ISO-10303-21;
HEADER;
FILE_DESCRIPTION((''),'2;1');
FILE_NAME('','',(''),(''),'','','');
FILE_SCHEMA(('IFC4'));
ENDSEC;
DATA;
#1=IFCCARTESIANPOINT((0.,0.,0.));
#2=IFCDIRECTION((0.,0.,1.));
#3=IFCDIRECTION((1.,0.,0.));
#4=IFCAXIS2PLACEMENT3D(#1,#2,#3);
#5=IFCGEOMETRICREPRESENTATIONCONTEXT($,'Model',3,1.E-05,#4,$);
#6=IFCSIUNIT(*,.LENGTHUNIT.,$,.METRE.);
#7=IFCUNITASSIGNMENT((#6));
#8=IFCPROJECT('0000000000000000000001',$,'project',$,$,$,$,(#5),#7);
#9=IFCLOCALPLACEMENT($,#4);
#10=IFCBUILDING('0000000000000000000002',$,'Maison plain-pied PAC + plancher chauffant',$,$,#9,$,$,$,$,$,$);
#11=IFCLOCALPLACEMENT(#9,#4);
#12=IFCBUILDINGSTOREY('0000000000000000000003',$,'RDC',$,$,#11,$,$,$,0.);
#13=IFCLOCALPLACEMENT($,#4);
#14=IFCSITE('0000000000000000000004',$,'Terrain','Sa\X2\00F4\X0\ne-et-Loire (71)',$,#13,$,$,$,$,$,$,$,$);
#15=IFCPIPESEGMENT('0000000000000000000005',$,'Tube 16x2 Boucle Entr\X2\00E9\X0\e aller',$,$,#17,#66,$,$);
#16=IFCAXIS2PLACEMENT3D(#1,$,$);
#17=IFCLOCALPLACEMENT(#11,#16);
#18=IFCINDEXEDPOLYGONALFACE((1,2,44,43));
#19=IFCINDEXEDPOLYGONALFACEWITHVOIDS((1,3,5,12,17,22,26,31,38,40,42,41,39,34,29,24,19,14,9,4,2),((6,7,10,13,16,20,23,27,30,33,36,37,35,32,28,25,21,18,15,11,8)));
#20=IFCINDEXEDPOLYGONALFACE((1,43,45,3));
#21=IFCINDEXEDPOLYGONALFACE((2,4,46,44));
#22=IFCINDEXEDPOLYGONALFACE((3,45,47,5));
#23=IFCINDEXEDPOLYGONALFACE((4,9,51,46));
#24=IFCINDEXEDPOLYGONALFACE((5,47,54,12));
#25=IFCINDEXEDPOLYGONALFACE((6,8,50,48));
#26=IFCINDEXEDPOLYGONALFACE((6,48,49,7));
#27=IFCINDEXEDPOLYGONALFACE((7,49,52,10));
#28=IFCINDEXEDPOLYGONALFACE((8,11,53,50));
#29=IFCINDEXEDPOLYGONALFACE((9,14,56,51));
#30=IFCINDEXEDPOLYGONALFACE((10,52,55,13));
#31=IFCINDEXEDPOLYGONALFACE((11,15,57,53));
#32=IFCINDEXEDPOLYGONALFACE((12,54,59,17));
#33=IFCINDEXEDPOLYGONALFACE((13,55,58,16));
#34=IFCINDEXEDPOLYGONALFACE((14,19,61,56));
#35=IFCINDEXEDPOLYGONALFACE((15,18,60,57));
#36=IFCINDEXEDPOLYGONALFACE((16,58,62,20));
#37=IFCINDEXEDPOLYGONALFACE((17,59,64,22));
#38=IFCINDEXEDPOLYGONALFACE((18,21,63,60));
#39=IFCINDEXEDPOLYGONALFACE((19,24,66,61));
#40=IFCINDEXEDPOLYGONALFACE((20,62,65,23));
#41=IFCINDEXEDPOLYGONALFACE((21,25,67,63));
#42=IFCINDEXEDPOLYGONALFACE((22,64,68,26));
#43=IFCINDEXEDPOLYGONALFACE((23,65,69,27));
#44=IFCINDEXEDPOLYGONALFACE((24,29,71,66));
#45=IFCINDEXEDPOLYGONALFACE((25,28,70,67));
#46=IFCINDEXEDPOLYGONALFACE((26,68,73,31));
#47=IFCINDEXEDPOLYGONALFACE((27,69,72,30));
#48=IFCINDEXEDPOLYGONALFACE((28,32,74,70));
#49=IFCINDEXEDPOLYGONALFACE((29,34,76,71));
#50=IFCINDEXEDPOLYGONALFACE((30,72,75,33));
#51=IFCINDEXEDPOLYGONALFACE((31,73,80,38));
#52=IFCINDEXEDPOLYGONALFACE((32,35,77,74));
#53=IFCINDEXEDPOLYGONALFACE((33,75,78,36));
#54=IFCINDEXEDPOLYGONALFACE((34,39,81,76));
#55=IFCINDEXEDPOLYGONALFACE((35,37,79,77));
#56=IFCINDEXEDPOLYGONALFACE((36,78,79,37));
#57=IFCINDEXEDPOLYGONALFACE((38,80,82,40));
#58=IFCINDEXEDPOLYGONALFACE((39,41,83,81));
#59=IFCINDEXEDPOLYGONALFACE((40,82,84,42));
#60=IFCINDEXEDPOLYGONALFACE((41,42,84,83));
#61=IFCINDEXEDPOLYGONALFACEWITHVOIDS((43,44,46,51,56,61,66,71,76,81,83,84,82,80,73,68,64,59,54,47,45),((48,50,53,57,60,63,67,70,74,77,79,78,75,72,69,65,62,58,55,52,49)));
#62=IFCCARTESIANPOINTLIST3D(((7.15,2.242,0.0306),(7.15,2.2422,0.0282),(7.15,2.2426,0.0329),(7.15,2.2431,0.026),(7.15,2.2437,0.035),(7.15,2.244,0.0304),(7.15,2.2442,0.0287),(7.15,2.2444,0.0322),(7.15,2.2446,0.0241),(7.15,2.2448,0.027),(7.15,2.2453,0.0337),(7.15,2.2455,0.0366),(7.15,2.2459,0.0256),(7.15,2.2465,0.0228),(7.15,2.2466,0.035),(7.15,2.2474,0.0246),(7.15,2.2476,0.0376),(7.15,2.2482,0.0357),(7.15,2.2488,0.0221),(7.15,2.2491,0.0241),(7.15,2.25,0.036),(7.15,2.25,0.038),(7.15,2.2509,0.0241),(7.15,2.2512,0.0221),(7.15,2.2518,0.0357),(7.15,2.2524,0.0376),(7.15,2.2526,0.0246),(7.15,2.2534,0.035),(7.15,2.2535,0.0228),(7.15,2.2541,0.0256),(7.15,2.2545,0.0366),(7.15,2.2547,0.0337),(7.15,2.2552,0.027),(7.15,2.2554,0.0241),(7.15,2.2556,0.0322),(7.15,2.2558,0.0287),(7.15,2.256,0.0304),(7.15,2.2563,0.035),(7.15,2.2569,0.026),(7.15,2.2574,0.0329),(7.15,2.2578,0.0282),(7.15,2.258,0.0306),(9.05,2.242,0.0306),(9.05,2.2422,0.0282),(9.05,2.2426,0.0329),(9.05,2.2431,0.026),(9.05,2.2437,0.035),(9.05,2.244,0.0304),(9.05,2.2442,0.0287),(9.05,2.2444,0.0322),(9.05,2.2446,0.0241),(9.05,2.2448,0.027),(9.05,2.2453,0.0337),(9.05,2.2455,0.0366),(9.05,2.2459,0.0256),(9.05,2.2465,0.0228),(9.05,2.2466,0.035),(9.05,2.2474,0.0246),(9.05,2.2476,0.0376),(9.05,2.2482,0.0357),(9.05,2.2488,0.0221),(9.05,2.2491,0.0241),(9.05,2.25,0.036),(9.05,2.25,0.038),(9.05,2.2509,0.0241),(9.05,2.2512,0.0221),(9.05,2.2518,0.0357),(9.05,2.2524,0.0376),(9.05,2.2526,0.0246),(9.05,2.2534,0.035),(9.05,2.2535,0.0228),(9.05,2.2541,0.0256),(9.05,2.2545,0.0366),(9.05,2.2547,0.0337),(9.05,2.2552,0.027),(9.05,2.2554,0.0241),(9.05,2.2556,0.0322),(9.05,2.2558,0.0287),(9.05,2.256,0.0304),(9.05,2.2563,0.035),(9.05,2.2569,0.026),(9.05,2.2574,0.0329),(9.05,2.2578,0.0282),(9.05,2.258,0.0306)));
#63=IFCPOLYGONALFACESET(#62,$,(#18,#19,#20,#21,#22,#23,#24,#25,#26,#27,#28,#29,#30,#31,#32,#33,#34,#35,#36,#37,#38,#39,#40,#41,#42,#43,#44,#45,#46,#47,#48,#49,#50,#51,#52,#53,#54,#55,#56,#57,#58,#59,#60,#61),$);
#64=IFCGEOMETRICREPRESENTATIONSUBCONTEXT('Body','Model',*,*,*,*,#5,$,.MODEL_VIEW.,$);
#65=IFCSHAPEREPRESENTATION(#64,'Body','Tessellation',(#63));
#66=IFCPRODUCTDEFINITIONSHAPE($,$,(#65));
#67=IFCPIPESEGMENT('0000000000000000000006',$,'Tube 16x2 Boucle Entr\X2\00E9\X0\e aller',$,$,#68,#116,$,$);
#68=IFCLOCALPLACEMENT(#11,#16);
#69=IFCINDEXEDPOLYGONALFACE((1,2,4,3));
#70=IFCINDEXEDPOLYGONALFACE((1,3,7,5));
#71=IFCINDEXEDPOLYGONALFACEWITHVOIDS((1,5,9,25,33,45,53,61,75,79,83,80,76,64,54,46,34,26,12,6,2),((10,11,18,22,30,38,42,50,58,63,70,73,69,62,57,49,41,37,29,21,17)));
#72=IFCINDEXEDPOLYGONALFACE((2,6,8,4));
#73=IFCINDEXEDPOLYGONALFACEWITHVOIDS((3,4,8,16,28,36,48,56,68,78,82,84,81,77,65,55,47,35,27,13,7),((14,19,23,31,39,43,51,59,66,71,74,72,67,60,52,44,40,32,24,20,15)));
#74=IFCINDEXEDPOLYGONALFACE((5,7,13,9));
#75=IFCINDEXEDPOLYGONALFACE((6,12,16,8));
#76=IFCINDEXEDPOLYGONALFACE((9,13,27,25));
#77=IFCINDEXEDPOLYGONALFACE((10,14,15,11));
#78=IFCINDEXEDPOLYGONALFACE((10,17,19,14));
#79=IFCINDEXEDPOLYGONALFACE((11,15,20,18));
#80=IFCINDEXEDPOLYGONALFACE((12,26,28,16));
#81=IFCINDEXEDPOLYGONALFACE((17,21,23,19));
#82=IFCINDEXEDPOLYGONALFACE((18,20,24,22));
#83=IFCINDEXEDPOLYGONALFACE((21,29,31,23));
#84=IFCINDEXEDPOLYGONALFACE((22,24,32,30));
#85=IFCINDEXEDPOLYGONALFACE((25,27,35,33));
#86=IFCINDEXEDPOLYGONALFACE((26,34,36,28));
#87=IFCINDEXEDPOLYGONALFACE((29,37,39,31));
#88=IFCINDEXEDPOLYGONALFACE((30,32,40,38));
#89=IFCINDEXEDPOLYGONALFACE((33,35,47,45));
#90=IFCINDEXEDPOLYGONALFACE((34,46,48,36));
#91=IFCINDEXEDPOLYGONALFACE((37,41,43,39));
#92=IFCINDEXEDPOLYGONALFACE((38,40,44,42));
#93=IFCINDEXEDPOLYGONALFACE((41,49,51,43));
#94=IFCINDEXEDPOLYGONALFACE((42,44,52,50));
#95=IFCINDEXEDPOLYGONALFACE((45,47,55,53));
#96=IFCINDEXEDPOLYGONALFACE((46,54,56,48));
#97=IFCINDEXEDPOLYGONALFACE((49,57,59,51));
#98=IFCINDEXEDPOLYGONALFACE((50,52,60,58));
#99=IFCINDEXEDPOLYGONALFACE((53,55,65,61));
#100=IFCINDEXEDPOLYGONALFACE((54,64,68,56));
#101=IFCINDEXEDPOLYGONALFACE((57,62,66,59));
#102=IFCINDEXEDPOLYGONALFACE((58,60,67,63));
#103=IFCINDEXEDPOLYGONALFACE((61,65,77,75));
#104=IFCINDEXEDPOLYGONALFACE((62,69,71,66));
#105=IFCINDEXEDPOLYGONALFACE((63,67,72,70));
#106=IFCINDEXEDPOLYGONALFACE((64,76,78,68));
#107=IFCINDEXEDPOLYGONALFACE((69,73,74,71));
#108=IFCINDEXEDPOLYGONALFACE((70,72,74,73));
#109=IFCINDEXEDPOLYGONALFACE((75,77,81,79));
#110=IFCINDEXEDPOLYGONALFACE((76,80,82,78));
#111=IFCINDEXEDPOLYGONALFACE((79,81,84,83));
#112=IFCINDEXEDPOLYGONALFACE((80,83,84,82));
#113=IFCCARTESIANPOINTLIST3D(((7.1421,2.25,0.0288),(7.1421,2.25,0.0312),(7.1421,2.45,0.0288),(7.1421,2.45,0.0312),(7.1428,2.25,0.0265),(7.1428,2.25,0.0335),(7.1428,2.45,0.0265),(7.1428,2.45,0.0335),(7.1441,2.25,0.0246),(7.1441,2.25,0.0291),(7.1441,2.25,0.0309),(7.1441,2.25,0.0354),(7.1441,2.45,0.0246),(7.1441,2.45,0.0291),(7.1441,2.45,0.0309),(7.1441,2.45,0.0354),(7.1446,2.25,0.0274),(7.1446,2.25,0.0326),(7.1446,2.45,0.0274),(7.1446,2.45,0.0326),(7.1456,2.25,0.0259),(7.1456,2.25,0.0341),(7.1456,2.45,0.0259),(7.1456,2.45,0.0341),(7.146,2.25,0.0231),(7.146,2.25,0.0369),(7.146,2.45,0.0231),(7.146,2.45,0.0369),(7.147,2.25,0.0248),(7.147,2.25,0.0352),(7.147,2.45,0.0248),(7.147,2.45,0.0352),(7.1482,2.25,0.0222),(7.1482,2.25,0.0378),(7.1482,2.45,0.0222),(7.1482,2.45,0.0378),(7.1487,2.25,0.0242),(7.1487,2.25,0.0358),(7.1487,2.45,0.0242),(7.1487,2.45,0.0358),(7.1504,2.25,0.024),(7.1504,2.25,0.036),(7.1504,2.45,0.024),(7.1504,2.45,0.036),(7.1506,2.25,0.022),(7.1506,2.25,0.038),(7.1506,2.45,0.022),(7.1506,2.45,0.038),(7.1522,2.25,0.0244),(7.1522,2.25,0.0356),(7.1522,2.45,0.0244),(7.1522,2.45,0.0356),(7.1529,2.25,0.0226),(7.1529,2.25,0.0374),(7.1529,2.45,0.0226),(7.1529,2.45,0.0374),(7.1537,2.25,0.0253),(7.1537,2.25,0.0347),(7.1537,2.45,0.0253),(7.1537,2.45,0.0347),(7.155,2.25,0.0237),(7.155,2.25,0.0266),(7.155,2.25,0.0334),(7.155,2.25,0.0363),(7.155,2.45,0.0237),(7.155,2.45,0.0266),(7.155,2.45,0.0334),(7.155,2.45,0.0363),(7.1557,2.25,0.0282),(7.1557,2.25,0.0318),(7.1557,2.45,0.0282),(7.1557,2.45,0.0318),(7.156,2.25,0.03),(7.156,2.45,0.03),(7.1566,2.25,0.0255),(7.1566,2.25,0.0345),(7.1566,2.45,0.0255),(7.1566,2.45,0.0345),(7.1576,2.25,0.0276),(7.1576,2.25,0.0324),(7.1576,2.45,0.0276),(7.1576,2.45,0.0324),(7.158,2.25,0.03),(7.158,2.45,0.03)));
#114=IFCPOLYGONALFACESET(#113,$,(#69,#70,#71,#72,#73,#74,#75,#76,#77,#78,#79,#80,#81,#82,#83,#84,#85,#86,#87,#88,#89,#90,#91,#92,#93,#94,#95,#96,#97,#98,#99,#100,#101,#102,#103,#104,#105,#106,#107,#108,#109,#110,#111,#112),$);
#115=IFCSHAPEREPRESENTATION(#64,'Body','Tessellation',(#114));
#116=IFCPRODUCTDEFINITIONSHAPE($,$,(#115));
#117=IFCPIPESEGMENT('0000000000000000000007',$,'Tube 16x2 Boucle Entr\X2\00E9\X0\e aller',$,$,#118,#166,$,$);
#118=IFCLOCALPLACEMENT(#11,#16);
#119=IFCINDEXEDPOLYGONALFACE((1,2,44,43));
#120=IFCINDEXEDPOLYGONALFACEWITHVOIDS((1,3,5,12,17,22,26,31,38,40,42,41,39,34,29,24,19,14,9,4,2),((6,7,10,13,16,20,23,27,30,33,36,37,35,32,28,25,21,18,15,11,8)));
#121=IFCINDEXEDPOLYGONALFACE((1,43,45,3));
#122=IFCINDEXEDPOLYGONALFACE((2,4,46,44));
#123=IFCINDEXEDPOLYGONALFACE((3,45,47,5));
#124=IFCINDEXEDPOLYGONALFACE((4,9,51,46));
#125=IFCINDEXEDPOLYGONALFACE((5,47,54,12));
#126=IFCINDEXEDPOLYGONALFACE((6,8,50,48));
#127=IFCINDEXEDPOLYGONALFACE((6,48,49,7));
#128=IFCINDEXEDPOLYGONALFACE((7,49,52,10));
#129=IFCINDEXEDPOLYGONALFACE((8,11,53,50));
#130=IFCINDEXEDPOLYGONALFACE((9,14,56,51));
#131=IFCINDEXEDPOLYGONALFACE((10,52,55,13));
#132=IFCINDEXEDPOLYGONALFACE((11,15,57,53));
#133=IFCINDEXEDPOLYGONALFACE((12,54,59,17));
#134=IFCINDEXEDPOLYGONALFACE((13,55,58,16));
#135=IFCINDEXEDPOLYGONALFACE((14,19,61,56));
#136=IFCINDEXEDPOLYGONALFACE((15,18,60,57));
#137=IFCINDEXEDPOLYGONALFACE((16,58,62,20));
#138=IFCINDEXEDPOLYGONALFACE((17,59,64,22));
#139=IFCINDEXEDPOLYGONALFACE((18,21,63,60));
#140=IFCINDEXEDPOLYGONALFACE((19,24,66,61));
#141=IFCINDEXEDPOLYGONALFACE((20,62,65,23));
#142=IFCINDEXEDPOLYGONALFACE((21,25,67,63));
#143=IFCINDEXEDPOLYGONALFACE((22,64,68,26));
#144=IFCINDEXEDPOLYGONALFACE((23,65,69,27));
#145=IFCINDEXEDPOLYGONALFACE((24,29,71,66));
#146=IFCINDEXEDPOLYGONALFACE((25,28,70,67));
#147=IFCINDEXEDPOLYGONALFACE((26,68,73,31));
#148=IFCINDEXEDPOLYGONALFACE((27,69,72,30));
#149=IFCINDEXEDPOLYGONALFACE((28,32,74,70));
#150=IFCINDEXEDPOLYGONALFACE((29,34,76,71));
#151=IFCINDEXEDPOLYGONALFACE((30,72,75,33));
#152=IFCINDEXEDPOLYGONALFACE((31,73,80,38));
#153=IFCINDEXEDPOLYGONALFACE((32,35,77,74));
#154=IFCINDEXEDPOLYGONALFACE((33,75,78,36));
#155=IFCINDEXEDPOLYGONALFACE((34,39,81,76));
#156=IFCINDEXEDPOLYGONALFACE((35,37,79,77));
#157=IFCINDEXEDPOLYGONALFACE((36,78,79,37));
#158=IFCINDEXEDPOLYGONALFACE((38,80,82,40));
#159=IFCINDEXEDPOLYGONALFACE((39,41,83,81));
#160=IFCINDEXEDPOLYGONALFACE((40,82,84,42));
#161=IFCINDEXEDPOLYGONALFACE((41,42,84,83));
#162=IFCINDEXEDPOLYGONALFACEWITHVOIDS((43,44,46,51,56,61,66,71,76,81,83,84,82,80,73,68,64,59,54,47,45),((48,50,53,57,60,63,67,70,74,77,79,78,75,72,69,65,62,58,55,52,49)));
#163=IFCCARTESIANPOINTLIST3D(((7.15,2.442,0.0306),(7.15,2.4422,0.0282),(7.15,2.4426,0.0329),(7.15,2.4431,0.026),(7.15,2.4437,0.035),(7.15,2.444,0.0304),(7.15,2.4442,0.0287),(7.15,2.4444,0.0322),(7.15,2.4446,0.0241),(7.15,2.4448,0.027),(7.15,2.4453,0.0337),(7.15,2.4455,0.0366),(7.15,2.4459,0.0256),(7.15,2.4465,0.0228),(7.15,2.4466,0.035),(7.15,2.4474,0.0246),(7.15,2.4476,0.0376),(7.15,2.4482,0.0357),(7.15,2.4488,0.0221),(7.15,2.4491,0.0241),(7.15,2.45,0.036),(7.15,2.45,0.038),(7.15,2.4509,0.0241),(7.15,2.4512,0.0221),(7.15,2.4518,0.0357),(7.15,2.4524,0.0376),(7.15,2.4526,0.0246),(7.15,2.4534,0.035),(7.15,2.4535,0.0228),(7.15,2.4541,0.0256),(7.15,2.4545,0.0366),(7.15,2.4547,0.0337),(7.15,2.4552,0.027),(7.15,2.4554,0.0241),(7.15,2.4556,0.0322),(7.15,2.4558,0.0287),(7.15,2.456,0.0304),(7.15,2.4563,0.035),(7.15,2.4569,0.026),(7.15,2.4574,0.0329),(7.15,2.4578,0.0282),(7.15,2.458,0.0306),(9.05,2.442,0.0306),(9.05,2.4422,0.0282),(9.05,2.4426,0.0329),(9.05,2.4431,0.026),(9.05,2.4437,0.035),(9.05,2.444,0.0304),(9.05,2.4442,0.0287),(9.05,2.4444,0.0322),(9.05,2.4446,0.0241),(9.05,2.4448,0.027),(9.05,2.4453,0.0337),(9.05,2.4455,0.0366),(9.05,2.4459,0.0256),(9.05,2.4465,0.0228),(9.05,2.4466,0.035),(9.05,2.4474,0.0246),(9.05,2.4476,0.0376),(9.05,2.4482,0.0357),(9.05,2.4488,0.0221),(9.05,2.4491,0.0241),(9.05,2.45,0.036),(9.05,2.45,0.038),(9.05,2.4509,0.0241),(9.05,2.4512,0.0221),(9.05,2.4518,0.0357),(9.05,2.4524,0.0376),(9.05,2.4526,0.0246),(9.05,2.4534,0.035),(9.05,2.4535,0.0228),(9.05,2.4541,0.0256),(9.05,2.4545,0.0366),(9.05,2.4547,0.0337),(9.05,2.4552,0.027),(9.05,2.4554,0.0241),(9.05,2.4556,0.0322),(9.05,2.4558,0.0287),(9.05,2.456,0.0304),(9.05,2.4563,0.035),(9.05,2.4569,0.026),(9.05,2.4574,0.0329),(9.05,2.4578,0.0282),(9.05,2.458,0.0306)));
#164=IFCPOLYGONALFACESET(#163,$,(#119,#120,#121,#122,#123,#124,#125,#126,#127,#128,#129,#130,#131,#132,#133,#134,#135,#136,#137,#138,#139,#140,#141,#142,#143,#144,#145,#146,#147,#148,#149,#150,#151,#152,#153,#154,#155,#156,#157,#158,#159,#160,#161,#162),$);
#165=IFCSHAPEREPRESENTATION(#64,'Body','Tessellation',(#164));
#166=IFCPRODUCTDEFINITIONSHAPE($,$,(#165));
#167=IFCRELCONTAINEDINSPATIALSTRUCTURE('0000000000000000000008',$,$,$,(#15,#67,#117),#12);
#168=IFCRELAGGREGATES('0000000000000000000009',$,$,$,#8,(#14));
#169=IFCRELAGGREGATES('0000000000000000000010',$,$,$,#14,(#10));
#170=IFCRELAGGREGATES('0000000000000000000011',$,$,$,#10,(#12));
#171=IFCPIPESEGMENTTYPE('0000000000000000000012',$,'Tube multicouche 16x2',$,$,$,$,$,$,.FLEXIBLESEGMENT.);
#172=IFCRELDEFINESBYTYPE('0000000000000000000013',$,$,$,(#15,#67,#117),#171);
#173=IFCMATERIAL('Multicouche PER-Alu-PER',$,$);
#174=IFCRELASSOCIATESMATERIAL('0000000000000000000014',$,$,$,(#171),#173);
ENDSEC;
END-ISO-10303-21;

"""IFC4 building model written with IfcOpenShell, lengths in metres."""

from ifc_helpers import new_model, si_unit, frame, origin_with_axes, place, context, subcontext, project, spatial, hollow_circle, extrude, material, type_object, element, save


model = new_model("IFC4")

# Units and contexts
model_context = context("Model", 3, precision=1e-05, world=origin_with_axes())
body_context = subcontext(model_context, "Body", "Model", "MODEL_VIEW")
ifc_project = project(units=[si_unit("LENGTHUNIT", "METRE")], contexts=[model_context])

# Site, building, storey
site_placement = place(None, origin_with_axes())
site = spatial("IfcSite", under=ifc_project, at=site_placement, Name="Terrain", Description="Saône-et-Loire (71)")
building_placement = place(None, origin_with_axes())
building = spatial("IfcBuilding", under=site, at=building_placement, Name="Maison plain-pied PAC + plancher chauffant")
storey_placement = place(building_placement, origin_with_axes())
storey = spatial("IfcBuildingStorey", under=building, at=storey_placement, Name="RDC", Elevation=0.0)

# Pipe segments
ifc_material_1 = material(Name="Multicouche PER-Alu-PER")
pipe_segment_type = type_object("IfcPipeSegmentType", Name="Tube multicouche 16x2", PredefinedType="FLEXIBLESEGMENT", material=ifc_material_1)
pipe_segment_1_placement = place(storey_placement, frame((9.05, 2.25, 0.03), z_axis=(-1.0, 0.0, 0.0), x_axis=(0.0, 0.0, 1.0)))
element("IfcPipeSegment", 1, at=pipe_segment_1_placement, inside=storey, type_object=pipe_segment_type, Name="Tube 16x2 Boucle Entrée aller", context=body_context, shape_type="SweptSolid", body=[
    extrude(hollow_circle(Radius=0.008, WallThickness=0.002), origin_with_axes(), (0.0, 0.0, 1.0), 1.9),
])
pipe_segment_2_placement = place(storey_placement, frame((7.15, 2.25, 0.03), z_axis=(0.0, 1.0, 0.0), x_axis=(1.0, 0.0, 0.0)))
element("IfcPipeSegment", 2, at=pipe_segment_2_placement, inside=storey, type_object=pipe_segment_type, Name="Tube 16x2 Boucle Entrée aller", context=body_context, shape_type="SweptSolid", body=[
    extrude(hollow_circle(Radius=0.008, WallThickness=0.002), origin_with_axes(), (0.0, 0.0, 1.0), 0.2),
])
pipe_segment_3_placement = place(storey_placement, frame((7.15, 2.45, 0.03), z_axis=(1.0, 0.0, 0.0), x_axis=(0.0, 0.0, 1.0)))
element("IfcPipeSegment", 3, at=pipe_segment_3_placement, inside=storey, type_object=pipe_segment_type, Name="Tube 16x2 Boucle Entrée aller", context=body_context, shape_type="SweptSolid", body=[
    extrude(hollow_circle(Radius=0.008, WallThickness=0.002), origin_with_axes(), (0.0, 0.0, 1.0), 1.9),
])

save(model, "model.ifc")
